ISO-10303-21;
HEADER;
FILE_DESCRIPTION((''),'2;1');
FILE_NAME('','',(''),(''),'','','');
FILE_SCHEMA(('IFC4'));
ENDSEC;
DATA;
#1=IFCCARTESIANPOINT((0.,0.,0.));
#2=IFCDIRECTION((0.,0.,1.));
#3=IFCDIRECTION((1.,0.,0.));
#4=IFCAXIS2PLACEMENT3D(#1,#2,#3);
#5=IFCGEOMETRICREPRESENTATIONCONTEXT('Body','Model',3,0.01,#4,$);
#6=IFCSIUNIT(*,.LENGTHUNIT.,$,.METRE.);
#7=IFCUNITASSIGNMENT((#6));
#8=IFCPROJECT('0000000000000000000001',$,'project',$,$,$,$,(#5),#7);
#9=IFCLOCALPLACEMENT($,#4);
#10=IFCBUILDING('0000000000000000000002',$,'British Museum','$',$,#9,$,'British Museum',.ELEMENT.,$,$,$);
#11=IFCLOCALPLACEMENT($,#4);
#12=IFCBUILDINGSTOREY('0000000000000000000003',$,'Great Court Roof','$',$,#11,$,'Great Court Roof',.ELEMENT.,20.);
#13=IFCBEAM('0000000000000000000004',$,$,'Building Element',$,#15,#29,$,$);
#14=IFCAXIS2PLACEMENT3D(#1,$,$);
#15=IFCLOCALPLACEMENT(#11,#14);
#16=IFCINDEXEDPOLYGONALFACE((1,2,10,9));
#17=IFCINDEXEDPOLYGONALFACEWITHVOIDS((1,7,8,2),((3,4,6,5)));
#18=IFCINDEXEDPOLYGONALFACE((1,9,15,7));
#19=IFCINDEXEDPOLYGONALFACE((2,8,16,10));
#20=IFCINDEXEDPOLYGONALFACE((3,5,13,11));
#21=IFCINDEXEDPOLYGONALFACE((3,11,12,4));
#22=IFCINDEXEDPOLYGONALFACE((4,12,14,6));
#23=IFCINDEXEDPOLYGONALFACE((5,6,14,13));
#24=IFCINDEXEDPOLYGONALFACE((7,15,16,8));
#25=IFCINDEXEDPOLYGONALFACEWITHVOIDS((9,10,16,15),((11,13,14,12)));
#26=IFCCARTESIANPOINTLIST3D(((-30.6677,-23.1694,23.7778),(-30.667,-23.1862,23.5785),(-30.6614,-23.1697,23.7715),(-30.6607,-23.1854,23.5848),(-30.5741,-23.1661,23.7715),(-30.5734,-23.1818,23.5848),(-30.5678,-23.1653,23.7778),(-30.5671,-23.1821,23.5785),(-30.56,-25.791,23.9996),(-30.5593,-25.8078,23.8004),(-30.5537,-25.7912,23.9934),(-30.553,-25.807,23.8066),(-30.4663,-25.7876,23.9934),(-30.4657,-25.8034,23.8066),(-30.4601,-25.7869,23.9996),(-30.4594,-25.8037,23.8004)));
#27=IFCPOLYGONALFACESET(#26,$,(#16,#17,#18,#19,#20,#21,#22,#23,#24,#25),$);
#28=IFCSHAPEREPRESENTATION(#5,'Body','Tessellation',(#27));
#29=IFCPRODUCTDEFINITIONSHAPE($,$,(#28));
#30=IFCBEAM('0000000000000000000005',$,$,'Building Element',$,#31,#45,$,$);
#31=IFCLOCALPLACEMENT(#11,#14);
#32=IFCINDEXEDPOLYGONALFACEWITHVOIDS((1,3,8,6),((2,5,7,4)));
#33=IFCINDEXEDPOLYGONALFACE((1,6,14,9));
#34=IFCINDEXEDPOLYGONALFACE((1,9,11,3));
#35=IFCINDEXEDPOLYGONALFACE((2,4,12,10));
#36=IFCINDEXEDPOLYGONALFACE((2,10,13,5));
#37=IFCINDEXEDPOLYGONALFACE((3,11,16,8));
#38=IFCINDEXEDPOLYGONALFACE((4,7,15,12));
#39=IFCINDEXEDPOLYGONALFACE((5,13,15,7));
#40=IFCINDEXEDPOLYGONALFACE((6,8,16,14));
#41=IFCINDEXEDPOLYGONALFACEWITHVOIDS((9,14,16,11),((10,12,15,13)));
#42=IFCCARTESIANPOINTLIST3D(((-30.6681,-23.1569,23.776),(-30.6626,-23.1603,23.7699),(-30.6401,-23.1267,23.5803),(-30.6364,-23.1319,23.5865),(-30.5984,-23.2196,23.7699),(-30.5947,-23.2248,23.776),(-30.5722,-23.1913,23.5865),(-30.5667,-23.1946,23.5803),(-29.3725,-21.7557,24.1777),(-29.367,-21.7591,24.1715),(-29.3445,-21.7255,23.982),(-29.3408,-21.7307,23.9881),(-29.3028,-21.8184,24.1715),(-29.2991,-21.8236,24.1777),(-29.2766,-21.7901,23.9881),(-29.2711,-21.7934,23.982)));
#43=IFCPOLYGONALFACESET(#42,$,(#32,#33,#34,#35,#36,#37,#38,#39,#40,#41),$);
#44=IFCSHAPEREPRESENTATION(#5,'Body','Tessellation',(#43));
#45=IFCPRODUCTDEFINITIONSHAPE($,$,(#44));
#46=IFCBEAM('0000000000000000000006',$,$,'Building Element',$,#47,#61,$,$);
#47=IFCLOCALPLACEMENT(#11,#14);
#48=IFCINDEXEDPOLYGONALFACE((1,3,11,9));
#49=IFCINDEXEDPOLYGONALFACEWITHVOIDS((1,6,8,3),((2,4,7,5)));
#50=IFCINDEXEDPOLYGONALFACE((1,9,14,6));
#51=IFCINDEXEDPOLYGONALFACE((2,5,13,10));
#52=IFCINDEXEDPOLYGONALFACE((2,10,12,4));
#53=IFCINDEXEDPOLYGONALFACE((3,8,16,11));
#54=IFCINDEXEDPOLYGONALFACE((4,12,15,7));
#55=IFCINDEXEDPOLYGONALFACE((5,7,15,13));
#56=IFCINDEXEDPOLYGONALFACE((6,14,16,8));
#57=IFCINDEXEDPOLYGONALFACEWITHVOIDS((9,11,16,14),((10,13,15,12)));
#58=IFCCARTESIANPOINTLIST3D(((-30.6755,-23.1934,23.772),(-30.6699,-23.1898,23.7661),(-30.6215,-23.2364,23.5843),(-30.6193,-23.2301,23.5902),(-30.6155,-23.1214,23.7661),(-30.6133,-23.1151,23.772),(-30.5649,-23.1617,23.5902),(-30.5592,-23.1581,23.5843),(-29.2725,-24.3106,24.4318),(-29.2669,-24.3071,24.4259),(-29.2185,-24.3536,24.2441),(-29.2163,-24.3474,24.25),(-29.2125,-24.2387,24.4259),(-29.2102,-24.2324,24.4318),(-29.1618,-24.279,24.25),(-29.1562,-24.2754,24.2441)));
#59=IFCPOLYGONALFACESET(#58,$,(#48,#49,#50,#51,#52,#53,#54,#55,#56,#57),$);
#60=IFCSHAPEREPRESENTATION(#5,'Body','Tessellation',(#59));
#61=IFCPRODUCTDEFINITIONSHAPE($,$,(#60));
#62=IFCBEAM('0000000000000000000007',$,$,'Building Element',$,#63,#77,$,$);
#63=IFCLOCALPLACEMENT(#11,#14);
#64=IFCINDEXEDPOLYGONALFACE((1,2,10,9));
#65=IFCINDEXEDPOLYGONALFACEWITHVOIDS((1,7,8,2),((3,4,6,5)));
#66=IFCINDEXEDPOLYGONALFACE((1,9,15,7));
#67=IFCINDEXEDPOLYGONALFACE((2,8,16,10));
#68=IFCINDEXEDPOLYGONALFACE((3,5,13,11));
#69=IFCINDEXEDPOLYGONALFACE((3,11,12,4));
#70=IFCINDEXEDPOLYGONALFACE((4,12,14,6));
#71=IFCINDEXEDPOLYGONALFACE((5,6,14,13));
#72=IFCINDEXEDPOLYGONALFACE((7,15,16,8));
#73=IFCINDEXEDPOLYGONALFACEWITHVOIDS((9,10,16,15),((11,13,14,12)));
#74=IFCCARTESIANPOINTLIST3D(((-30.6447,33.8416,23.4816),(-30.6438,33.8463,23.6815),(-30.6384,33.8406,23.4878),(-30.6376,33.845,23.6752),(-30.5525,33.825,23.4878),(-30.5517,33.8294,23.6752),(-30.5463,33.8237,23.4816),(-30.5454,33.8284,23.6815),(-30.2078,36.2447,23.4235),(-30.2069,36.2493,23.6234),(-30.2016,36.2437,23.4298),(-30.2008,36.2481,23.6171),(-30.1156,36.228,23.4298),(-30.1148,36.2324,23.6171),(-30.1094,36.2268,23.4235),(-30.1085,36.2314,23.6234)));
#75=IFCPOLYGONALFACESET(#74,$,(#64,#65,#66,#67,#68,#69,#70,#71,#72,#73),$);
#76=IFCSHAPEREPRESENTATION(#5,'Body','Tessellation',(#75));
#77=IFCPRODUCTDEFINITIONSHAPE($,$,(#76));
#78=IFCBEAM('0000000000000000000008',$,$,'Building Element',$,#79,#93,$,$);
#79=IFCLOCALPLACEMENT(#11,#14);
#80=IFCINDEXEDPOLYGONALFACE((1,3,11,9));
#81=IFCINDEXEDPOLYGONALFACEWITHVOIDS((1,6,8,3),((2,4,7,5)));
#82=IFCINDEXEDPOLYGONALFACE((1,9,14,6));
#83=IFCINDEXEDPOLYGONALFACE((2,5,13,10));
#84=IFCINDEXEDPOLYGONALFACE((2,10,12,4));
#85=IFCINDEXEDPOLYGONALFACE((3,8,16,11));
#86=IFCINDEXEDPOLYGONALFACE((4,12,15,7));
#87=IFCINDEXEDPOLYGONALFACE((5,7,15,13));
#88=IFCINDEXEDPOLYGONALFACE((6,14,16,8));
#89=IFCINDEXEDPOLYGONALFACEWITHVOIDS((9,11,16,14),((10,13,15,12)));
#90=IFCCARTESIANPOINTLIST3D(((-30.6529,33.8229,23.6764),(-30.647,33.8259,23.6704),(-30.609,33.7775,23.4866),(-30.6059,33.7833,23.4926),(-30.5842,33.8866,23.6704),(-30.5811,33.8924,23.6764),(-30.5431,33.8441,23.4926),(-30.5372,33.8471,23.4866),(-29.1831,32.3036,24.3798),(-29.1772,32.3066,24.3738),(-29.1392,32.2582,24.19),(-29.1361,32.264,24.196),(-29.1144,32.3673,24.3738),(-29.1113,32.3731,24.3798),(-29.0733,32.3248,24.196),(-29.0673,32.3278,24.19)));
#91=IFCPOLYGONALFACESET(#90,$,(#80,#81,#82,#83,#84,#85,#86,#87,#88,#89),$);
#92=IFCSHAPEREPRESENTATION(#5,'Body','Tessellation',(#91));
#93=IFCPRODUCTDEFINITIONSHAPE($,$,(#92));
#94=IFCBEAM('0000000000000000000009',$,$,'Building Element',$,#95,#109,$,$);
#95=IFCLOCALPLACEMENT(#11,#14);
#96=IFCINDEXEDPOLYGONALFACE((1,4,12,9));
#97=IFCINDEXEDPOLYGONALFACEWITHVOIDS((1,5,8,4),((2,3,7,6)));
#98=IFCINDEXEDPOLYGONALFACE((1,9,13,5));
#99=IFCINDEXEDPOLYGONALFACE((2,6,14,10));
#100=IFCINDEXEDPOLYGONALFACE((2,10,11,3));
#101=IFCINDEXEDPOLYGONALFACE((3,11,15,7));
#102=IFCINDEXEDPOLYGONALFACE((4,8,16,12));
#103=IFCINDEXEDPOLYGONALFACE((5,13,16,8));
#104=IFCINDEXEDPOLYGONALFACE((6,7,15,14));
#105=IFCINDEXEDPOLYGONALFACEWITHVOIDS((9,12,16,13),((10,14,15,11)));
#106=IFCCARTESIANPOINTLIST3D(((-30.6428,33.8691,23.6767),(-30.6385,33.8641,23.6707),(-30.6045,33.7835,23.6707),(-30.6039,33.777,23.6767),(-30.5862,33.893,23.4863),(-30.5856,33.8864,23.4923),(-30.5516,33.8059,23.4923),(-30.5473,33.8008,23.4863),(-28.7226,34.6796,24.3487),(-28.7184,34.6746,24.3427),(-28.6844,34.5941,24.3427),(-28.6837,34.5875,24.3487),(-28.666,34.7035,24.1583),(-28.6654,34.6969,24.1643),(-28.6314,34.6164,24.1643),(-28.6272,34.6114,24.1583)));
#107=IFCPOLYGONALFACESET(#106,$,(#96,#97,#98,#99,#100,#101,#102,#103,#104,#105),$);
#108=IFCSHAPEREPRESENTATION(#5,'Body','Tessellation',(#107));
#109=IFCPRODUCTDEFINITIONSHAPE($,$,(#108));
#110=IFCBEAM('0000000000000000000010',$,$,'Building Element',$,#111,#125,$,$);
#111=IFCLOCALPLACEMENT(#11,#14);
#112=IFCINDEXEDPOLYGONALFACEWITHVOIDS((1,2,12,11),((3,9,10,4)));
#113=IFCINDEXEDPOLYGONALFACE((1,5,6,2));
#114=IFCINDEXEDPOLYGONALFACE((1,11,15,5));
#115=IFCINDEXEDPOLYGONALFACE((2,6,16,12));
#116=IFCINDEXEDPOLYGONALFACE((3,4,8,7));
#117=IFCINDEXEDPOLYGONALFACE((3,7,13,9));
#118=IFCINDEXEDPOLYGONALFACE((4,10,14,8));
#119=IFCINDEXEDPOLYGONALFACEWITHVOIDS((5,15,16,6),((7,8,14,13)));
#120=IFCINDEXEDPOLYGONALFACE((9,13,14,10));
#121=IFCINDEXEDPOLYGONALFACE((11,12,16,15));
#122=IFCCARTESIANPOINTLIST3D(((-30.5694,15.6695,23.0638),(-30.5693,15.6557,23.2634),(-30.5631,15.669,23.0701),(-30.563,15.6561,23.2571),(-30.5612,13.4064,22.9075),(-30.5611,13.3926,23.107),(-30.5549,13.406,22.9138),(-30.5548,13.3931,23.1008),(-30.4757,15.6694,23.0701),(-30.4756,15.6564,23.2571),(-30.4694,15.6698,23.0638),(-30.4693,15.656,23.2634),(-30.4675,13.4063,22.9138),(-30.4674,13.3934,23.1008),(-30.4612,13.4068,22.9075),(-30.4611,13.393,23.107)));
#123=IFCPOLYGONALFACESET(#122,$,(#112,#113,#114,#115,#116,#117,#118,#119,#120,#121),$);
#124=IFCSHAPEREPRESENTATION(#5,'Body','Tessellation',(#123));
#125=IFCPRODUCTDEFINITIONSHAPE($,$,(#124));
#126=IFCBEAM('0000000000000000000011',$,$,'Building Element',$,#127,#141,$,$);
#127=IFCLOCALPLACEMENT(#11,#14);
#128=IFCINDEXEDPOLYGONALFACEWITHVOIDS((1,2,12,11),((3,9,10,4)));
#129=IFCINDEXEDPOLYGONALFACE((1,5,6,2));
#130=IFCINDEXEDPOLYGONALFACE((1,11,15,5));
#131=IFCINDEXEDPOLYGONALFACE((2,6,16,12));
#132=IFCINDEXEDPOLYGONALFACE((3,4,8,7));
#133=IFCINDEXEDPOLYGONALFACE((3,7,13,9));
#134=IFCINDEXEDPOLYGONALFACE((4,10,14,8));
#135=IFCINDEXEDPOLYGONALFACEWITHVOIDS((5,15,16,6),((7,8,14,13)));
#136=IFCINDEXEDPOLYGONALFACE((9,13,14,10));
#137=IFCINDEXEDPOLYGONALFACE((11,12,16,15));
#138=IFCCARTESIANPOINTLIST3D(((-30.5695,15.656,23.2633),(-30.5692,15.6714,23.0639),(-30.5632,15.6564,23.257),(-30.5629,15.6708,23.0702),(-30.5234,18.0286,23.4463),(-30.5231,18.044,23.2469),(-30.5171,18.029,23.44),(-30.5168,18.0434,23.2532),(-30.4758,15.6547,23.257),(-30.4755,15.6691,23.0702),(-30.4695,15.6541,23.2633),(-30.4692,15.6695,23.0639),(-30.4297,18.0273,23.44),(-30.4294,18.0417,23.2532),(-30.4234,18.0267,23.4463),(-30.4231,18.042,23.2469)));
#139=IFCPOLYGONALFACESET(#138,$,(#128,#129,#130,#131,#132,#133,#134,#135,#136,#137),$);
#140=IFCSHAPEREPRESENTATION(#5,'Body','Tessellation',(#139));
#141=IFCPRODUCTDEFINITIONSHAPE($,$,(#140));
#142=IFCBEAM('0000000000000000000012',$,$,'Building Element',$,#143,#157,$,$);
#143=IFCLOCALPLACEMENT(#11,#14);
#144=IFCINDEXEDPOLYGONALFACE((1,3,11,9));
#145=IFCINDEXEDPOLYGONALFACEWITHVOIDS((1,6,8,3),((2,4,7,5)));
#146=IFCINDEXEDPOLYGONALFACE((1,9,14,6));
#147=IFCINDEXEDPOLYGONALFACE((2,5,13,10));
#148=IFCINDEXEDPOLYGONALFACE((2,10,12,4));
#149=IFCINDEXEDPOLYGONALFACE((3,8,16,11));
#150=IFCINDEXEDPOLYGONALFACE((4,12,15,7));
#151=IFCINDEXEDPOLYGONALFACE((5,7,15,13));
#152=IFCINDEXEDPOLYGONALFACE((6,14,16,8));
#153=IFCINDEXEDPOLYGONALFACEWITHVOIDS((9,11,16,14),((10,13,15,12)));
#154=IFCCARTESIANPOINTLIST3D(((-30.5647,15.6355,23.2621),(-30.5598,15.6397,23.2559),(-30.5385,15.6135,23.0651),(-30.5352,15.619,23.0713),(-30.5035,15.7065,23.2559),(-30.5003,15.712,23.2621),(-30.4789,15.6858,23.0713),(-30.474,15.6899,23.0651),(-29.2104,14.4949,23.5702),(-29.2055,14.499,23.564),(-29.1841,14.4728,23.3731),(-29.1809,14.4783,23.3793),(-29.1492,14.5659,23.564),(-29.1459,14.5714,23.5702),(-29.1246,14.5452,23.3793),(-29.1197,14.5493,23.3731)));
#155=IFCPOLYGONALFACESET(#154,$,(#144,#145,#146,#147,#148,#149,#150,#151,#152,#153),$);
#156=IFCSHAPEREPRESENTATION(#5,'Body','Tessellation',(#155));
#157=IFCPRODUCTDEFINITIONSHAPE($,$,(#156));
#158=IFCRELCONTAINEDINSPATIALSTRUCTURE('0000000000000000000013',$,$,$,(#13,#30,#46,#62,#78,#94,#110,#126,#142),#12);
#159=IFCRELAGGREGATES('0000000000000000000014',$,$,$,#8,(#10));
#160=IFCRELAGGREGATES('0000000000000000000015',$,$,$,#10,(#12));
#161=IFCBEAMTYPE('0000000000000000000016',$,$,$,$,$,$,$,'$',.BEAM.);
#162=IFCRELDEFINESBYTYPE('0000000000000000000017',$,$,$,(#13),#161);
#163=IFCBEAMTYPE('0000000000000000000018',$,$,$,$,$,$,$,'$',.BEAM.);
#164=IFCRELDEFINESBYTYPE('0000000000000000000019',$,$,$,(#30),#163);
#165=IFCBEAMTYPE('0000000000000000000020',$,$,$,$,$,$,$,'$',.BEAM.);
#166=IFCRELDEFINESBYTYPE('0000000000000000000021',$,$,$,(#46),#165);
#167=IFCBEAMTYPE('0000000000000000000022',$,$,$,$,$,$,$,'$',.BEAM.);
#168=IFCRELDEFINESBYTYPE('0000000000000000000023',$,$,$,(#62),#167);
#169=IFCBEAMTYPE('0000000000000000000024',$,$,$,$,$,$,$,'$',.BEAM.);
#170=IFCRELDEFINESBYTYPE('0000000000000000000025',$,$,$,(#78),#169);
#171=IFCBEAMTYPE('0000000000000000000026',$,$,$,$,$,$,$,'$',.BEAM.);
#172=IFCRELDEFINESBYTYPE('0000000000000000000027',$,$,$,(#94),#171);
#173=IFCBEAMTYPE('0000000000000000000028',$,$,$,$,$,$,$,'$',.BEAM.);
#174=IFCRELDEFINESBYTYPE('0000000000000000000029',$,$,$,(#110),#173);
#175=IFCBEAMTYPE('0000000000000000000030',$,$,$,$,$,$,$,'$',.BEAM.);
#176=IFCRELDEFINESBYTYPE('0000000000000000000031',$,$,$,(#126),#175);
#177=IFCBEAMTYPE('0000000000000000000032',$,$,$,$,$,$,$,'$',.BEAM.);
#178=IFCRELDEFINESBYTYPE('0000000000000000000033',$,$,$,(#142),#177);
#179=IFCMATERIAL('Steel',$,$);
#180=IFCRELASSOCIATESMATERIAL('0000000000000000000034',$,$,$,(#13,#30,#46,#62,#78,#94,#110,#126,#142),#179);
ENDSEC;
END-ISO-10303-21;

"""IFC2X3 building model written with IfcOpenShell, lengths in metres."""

from ifc_helpers import new_model, si_unit, frame, origin_with_axes, origin_2d, place, context, project, spatial, hollow_rectangle, extrude, material, type_object, element, save


model = new_model("IFC2X3")

# Units and contexts
model_context = context("Model", 3, precision=0.01, world=origin_with_axes(), identifier="Body")
ifc_project = project(units=[si_unit("LENGTHUNIT", "METRE")], contexts=[model_context])

# Building, storey
building_placement = place(None, origin_with_axes())
building = spatial("IfcBuilding", under=ifc_project, at=building_placement, Name="British Museum", Description="$", LongName="British Museum", CompositionType="ELEMENT")
storey_placement = place(None, origin_with_axes())
storey = spatial("IfcBuildingStorey", under=building, at=storey_placement, Name="Great Court Roof", Description="$", LongName="Great Court Roof", CompositionType="ELEMENT", Elevation=20.0)

# Beams
ifc_material = material(Name="Steel")
beam_type_1 = type_object("IfcBeamType", ElementType="$", PredefinedType="BEAM")
beam_1_placement = place(None, origin_with_axes())
element("IfcBeam", 1, at=beam_1_placement, inside=storey, type_object=beam_type_1, material=ifc_material, Description="Building Element", context=model_context, shape_type="SweptSolid", body=[
    extrude(hollow_rectangle(XDim=0.1, YDim=0.2, WallThickness=0.0063, InnerFilletRadius=0.0, OuterFilletRadius=0.0, at=origin_2d()), frame((-30.6174, -23.1758, 23.6782), z_axis=(0.040913, -0.995605, 0.084248), x_axis=(0.999157, 0.041059, 0.0)), (0.0, 0.0, 1.0), 2.6331),
])
beam_type_2 = type_object("IfcBeamType", ElementType="$", PredefinedType="BEAM")
beam_2_placement = place(None, origin_with_axes())
element("IfcBeam", 2, at=beam_2_placement, inside=storey, type_object=beam_type_2, material=ifc_material, Description="Building Element", context=model_context, shape_type="SweptSolid", body=[
    extrude(hollow_rectangle(XDim=0.1, YDim=0.2, WallThickness=0.0063, InnerFilletRadius=0.0, OuterFilletRadius=0.0, at=origin_2d()), frame((-30.6174, -23.1758, 23.6782), z_axis=(0.664345, 0.71849, 0.205955), x_axis=(-0.734231, 0.6789, 0.0)), (0.0, 0.0, 1.0), 1.9502),
])
beam_type_3 = type_object("IfcBeamType", ElementType="$", PredefinedType="BEAM")
beam_3_placement = place(None, origin_with_axes())
element("IfcBeam", 3, at=beam_3_placement, inside=storey, type_object=beam_type_3, material=ifc_material, Description="Building Element", context=model_context, shape_type="SweptSolid", body=[
    extrude(hollow_rectangle(XDim=0.1, YDim=0.2, WallThickness=0.0063, InnerFilletRadius=0.0, OuterFilletRadius=0.0, at=origin_2d()), frame((-30.6174, -23.1758, 23.6782), z_axis=(0.734163, -0.584636, 0.345262), x_axis=(0.622943, 0.782267, 0.0)), (0.0, 0.0, 1.0), 1.911),
])
beam_type_4 = type_object("IfcBeamType", ElementType="$", PredefinedType="BEAM")
beam_4_placement = place(None, origin_with_axes())
element("IfcBeam", 4, at=beam_4_placement, inside=storey, type_object=beam_type_4, material=ifc_material, Description="Building Element", context=model_context, shape_type="SweptSolid", body=[
    extrude(hollow_rectangle(XDim=0.1, YDim=0.2, WallThickness=0.0063, InnerFilletRadius=0.0, OuterFilletRadius=0.0, at=origin_2d()), frame((-30.595, 33.835, 23.5815), z_axis=(0.178821, 0.983595, -0.023766), x_axis=(-0.983873, 0.178871, 0.0)), (0.0, 0.0, 1.0), 2.4432),
])
beam_type_5 = type_object("IfcBeamType", ElementType="$", PredefinedType="BEAM")
beam_5_placement = place(None, origin_with_axes())
element("IfcBeam", 5, at=beam_5_placement, inside=storey, type_object=beam_type_5, material=ifc_material, Description="Building Element", context=model_context, shape_type="SweptSolid", body=[
    extrude(hollow_rectangle(XDim=0.1, YDim=0.2, WallThickness=0.0063, InnerFilletRadius=0.0, OuterFilletRadius=0.0, at=origin_2d()), frame((-30.595, 33.835, 23.5815), z_axis=(0.659744, -0.681952, 0.31572), x_axis=(0.718713, 0.695307, 0.0)), (0.0, 0.0, 1.0), 2.2279),
])
beam_type_6 = type_object("IfcBeamType", ElementType="$", PredefinedType="BEAM")
beam_6_placement = place(None, origin_with_axes())
element("IfcBeam", 6, at=beam_6_placement, inside=storey, type_object=beam_type_6, material=ifc_material, Description="Building Element", context=model_context, shape_type="SweptSolid", body=[
    extrude(hollow_rectangle(XDim=0.1, YDim=0.2, WallThickness=0.0063, InnerFilletRadius=0.0, OuterFilletRadius=0.0, at=origin_2d()), frame((-30.595, 33.835, 23.5815), z_axis=(0.876842, 0.370119, 0.306854), x_axis=(-0.38888, 0.921288, 0.0)), (0.0, 0.0, 1.0), 2.1899),
])
beam_type_7 = type_object("IfcBeamType", ElementType="$", PredefinedType="BEAM")
beam_7_placement = place(None, origin_with_axes())
element("IfcBeam", 7, at=beam_7_placement, inside=storey, type_object=beam_type_7, material=ifc_material, Description="Building Element", context=model_context, shape_type="SweptSolid", body=[
    extrude(hollow_rectangle(XDim=0.1, YDim=0.2, WallThickness=0.0063, InnerFilletRadius=0.0, OuterFilletRadius=0.0, at=origin_2d()), frame((-30.5194, 15.6627, 23.1636), z_axis=(0.003627, -0.997616, -0.068914), x_axis=(0.999993, 0.003636, 0.0)), (0.0, 0.0, 1.0), 2.2684),
])
beam_type_8 = type_object("IfcBeamType", ElementType="$", PredefinedType="BEAM")
beam_8_placement = place(None, origin_with_axes())
element("IfcBeam", 8, at=beam_8_placement, inside=storey, type_object=beam_type_8, material=ifc_material, Description="Building Element", context=model_context, shape_type="SweptSolid", body=[
    extrude(hollow_rectangle(XDim=0.1, YDim=0.2, WallThickness=0.0063, InnerFilletRadius=0.0, OuterFilletRadius=0.0, at=origin_2d()), frame((-30.5194, 15.6627, 23.1636), z_axis=(0.019372, 0.996852, 0.076877), x_axis=(-0.999811, 0.019429, 0.0)), (0.0, 0.0, 1.0), 2.3801),
])
beam_type_9 = type_object("IfcBeamType", ElementType="$", PredefinedType="BEAM")
beam_9_placement = place(None, origin_with_axes())
element("IfcBeam", 9, at=beam_9_placement, inside=storey, type_object=beam_type_9, material=ifc_material, Description="Building Element", context=model_context, shape_type="SweptSolid", body=[
    extrude(hollow_rectangle(XDim=0.1, YDim=0.2, WallThickness=0.0063, InnerFilletRadius=0.0, OuterFilletRadius=0.0, at=origin_2d()), frame((-30.5194, 15.6627, 23.1636), z_axis=(0.753546, -0.634661, 0.17139), x_axis=(0.644193, 0.764863, 0.0)), (0.0, 0.0, 1.0), 1.7973),
])

save(model, "model.ifc")
